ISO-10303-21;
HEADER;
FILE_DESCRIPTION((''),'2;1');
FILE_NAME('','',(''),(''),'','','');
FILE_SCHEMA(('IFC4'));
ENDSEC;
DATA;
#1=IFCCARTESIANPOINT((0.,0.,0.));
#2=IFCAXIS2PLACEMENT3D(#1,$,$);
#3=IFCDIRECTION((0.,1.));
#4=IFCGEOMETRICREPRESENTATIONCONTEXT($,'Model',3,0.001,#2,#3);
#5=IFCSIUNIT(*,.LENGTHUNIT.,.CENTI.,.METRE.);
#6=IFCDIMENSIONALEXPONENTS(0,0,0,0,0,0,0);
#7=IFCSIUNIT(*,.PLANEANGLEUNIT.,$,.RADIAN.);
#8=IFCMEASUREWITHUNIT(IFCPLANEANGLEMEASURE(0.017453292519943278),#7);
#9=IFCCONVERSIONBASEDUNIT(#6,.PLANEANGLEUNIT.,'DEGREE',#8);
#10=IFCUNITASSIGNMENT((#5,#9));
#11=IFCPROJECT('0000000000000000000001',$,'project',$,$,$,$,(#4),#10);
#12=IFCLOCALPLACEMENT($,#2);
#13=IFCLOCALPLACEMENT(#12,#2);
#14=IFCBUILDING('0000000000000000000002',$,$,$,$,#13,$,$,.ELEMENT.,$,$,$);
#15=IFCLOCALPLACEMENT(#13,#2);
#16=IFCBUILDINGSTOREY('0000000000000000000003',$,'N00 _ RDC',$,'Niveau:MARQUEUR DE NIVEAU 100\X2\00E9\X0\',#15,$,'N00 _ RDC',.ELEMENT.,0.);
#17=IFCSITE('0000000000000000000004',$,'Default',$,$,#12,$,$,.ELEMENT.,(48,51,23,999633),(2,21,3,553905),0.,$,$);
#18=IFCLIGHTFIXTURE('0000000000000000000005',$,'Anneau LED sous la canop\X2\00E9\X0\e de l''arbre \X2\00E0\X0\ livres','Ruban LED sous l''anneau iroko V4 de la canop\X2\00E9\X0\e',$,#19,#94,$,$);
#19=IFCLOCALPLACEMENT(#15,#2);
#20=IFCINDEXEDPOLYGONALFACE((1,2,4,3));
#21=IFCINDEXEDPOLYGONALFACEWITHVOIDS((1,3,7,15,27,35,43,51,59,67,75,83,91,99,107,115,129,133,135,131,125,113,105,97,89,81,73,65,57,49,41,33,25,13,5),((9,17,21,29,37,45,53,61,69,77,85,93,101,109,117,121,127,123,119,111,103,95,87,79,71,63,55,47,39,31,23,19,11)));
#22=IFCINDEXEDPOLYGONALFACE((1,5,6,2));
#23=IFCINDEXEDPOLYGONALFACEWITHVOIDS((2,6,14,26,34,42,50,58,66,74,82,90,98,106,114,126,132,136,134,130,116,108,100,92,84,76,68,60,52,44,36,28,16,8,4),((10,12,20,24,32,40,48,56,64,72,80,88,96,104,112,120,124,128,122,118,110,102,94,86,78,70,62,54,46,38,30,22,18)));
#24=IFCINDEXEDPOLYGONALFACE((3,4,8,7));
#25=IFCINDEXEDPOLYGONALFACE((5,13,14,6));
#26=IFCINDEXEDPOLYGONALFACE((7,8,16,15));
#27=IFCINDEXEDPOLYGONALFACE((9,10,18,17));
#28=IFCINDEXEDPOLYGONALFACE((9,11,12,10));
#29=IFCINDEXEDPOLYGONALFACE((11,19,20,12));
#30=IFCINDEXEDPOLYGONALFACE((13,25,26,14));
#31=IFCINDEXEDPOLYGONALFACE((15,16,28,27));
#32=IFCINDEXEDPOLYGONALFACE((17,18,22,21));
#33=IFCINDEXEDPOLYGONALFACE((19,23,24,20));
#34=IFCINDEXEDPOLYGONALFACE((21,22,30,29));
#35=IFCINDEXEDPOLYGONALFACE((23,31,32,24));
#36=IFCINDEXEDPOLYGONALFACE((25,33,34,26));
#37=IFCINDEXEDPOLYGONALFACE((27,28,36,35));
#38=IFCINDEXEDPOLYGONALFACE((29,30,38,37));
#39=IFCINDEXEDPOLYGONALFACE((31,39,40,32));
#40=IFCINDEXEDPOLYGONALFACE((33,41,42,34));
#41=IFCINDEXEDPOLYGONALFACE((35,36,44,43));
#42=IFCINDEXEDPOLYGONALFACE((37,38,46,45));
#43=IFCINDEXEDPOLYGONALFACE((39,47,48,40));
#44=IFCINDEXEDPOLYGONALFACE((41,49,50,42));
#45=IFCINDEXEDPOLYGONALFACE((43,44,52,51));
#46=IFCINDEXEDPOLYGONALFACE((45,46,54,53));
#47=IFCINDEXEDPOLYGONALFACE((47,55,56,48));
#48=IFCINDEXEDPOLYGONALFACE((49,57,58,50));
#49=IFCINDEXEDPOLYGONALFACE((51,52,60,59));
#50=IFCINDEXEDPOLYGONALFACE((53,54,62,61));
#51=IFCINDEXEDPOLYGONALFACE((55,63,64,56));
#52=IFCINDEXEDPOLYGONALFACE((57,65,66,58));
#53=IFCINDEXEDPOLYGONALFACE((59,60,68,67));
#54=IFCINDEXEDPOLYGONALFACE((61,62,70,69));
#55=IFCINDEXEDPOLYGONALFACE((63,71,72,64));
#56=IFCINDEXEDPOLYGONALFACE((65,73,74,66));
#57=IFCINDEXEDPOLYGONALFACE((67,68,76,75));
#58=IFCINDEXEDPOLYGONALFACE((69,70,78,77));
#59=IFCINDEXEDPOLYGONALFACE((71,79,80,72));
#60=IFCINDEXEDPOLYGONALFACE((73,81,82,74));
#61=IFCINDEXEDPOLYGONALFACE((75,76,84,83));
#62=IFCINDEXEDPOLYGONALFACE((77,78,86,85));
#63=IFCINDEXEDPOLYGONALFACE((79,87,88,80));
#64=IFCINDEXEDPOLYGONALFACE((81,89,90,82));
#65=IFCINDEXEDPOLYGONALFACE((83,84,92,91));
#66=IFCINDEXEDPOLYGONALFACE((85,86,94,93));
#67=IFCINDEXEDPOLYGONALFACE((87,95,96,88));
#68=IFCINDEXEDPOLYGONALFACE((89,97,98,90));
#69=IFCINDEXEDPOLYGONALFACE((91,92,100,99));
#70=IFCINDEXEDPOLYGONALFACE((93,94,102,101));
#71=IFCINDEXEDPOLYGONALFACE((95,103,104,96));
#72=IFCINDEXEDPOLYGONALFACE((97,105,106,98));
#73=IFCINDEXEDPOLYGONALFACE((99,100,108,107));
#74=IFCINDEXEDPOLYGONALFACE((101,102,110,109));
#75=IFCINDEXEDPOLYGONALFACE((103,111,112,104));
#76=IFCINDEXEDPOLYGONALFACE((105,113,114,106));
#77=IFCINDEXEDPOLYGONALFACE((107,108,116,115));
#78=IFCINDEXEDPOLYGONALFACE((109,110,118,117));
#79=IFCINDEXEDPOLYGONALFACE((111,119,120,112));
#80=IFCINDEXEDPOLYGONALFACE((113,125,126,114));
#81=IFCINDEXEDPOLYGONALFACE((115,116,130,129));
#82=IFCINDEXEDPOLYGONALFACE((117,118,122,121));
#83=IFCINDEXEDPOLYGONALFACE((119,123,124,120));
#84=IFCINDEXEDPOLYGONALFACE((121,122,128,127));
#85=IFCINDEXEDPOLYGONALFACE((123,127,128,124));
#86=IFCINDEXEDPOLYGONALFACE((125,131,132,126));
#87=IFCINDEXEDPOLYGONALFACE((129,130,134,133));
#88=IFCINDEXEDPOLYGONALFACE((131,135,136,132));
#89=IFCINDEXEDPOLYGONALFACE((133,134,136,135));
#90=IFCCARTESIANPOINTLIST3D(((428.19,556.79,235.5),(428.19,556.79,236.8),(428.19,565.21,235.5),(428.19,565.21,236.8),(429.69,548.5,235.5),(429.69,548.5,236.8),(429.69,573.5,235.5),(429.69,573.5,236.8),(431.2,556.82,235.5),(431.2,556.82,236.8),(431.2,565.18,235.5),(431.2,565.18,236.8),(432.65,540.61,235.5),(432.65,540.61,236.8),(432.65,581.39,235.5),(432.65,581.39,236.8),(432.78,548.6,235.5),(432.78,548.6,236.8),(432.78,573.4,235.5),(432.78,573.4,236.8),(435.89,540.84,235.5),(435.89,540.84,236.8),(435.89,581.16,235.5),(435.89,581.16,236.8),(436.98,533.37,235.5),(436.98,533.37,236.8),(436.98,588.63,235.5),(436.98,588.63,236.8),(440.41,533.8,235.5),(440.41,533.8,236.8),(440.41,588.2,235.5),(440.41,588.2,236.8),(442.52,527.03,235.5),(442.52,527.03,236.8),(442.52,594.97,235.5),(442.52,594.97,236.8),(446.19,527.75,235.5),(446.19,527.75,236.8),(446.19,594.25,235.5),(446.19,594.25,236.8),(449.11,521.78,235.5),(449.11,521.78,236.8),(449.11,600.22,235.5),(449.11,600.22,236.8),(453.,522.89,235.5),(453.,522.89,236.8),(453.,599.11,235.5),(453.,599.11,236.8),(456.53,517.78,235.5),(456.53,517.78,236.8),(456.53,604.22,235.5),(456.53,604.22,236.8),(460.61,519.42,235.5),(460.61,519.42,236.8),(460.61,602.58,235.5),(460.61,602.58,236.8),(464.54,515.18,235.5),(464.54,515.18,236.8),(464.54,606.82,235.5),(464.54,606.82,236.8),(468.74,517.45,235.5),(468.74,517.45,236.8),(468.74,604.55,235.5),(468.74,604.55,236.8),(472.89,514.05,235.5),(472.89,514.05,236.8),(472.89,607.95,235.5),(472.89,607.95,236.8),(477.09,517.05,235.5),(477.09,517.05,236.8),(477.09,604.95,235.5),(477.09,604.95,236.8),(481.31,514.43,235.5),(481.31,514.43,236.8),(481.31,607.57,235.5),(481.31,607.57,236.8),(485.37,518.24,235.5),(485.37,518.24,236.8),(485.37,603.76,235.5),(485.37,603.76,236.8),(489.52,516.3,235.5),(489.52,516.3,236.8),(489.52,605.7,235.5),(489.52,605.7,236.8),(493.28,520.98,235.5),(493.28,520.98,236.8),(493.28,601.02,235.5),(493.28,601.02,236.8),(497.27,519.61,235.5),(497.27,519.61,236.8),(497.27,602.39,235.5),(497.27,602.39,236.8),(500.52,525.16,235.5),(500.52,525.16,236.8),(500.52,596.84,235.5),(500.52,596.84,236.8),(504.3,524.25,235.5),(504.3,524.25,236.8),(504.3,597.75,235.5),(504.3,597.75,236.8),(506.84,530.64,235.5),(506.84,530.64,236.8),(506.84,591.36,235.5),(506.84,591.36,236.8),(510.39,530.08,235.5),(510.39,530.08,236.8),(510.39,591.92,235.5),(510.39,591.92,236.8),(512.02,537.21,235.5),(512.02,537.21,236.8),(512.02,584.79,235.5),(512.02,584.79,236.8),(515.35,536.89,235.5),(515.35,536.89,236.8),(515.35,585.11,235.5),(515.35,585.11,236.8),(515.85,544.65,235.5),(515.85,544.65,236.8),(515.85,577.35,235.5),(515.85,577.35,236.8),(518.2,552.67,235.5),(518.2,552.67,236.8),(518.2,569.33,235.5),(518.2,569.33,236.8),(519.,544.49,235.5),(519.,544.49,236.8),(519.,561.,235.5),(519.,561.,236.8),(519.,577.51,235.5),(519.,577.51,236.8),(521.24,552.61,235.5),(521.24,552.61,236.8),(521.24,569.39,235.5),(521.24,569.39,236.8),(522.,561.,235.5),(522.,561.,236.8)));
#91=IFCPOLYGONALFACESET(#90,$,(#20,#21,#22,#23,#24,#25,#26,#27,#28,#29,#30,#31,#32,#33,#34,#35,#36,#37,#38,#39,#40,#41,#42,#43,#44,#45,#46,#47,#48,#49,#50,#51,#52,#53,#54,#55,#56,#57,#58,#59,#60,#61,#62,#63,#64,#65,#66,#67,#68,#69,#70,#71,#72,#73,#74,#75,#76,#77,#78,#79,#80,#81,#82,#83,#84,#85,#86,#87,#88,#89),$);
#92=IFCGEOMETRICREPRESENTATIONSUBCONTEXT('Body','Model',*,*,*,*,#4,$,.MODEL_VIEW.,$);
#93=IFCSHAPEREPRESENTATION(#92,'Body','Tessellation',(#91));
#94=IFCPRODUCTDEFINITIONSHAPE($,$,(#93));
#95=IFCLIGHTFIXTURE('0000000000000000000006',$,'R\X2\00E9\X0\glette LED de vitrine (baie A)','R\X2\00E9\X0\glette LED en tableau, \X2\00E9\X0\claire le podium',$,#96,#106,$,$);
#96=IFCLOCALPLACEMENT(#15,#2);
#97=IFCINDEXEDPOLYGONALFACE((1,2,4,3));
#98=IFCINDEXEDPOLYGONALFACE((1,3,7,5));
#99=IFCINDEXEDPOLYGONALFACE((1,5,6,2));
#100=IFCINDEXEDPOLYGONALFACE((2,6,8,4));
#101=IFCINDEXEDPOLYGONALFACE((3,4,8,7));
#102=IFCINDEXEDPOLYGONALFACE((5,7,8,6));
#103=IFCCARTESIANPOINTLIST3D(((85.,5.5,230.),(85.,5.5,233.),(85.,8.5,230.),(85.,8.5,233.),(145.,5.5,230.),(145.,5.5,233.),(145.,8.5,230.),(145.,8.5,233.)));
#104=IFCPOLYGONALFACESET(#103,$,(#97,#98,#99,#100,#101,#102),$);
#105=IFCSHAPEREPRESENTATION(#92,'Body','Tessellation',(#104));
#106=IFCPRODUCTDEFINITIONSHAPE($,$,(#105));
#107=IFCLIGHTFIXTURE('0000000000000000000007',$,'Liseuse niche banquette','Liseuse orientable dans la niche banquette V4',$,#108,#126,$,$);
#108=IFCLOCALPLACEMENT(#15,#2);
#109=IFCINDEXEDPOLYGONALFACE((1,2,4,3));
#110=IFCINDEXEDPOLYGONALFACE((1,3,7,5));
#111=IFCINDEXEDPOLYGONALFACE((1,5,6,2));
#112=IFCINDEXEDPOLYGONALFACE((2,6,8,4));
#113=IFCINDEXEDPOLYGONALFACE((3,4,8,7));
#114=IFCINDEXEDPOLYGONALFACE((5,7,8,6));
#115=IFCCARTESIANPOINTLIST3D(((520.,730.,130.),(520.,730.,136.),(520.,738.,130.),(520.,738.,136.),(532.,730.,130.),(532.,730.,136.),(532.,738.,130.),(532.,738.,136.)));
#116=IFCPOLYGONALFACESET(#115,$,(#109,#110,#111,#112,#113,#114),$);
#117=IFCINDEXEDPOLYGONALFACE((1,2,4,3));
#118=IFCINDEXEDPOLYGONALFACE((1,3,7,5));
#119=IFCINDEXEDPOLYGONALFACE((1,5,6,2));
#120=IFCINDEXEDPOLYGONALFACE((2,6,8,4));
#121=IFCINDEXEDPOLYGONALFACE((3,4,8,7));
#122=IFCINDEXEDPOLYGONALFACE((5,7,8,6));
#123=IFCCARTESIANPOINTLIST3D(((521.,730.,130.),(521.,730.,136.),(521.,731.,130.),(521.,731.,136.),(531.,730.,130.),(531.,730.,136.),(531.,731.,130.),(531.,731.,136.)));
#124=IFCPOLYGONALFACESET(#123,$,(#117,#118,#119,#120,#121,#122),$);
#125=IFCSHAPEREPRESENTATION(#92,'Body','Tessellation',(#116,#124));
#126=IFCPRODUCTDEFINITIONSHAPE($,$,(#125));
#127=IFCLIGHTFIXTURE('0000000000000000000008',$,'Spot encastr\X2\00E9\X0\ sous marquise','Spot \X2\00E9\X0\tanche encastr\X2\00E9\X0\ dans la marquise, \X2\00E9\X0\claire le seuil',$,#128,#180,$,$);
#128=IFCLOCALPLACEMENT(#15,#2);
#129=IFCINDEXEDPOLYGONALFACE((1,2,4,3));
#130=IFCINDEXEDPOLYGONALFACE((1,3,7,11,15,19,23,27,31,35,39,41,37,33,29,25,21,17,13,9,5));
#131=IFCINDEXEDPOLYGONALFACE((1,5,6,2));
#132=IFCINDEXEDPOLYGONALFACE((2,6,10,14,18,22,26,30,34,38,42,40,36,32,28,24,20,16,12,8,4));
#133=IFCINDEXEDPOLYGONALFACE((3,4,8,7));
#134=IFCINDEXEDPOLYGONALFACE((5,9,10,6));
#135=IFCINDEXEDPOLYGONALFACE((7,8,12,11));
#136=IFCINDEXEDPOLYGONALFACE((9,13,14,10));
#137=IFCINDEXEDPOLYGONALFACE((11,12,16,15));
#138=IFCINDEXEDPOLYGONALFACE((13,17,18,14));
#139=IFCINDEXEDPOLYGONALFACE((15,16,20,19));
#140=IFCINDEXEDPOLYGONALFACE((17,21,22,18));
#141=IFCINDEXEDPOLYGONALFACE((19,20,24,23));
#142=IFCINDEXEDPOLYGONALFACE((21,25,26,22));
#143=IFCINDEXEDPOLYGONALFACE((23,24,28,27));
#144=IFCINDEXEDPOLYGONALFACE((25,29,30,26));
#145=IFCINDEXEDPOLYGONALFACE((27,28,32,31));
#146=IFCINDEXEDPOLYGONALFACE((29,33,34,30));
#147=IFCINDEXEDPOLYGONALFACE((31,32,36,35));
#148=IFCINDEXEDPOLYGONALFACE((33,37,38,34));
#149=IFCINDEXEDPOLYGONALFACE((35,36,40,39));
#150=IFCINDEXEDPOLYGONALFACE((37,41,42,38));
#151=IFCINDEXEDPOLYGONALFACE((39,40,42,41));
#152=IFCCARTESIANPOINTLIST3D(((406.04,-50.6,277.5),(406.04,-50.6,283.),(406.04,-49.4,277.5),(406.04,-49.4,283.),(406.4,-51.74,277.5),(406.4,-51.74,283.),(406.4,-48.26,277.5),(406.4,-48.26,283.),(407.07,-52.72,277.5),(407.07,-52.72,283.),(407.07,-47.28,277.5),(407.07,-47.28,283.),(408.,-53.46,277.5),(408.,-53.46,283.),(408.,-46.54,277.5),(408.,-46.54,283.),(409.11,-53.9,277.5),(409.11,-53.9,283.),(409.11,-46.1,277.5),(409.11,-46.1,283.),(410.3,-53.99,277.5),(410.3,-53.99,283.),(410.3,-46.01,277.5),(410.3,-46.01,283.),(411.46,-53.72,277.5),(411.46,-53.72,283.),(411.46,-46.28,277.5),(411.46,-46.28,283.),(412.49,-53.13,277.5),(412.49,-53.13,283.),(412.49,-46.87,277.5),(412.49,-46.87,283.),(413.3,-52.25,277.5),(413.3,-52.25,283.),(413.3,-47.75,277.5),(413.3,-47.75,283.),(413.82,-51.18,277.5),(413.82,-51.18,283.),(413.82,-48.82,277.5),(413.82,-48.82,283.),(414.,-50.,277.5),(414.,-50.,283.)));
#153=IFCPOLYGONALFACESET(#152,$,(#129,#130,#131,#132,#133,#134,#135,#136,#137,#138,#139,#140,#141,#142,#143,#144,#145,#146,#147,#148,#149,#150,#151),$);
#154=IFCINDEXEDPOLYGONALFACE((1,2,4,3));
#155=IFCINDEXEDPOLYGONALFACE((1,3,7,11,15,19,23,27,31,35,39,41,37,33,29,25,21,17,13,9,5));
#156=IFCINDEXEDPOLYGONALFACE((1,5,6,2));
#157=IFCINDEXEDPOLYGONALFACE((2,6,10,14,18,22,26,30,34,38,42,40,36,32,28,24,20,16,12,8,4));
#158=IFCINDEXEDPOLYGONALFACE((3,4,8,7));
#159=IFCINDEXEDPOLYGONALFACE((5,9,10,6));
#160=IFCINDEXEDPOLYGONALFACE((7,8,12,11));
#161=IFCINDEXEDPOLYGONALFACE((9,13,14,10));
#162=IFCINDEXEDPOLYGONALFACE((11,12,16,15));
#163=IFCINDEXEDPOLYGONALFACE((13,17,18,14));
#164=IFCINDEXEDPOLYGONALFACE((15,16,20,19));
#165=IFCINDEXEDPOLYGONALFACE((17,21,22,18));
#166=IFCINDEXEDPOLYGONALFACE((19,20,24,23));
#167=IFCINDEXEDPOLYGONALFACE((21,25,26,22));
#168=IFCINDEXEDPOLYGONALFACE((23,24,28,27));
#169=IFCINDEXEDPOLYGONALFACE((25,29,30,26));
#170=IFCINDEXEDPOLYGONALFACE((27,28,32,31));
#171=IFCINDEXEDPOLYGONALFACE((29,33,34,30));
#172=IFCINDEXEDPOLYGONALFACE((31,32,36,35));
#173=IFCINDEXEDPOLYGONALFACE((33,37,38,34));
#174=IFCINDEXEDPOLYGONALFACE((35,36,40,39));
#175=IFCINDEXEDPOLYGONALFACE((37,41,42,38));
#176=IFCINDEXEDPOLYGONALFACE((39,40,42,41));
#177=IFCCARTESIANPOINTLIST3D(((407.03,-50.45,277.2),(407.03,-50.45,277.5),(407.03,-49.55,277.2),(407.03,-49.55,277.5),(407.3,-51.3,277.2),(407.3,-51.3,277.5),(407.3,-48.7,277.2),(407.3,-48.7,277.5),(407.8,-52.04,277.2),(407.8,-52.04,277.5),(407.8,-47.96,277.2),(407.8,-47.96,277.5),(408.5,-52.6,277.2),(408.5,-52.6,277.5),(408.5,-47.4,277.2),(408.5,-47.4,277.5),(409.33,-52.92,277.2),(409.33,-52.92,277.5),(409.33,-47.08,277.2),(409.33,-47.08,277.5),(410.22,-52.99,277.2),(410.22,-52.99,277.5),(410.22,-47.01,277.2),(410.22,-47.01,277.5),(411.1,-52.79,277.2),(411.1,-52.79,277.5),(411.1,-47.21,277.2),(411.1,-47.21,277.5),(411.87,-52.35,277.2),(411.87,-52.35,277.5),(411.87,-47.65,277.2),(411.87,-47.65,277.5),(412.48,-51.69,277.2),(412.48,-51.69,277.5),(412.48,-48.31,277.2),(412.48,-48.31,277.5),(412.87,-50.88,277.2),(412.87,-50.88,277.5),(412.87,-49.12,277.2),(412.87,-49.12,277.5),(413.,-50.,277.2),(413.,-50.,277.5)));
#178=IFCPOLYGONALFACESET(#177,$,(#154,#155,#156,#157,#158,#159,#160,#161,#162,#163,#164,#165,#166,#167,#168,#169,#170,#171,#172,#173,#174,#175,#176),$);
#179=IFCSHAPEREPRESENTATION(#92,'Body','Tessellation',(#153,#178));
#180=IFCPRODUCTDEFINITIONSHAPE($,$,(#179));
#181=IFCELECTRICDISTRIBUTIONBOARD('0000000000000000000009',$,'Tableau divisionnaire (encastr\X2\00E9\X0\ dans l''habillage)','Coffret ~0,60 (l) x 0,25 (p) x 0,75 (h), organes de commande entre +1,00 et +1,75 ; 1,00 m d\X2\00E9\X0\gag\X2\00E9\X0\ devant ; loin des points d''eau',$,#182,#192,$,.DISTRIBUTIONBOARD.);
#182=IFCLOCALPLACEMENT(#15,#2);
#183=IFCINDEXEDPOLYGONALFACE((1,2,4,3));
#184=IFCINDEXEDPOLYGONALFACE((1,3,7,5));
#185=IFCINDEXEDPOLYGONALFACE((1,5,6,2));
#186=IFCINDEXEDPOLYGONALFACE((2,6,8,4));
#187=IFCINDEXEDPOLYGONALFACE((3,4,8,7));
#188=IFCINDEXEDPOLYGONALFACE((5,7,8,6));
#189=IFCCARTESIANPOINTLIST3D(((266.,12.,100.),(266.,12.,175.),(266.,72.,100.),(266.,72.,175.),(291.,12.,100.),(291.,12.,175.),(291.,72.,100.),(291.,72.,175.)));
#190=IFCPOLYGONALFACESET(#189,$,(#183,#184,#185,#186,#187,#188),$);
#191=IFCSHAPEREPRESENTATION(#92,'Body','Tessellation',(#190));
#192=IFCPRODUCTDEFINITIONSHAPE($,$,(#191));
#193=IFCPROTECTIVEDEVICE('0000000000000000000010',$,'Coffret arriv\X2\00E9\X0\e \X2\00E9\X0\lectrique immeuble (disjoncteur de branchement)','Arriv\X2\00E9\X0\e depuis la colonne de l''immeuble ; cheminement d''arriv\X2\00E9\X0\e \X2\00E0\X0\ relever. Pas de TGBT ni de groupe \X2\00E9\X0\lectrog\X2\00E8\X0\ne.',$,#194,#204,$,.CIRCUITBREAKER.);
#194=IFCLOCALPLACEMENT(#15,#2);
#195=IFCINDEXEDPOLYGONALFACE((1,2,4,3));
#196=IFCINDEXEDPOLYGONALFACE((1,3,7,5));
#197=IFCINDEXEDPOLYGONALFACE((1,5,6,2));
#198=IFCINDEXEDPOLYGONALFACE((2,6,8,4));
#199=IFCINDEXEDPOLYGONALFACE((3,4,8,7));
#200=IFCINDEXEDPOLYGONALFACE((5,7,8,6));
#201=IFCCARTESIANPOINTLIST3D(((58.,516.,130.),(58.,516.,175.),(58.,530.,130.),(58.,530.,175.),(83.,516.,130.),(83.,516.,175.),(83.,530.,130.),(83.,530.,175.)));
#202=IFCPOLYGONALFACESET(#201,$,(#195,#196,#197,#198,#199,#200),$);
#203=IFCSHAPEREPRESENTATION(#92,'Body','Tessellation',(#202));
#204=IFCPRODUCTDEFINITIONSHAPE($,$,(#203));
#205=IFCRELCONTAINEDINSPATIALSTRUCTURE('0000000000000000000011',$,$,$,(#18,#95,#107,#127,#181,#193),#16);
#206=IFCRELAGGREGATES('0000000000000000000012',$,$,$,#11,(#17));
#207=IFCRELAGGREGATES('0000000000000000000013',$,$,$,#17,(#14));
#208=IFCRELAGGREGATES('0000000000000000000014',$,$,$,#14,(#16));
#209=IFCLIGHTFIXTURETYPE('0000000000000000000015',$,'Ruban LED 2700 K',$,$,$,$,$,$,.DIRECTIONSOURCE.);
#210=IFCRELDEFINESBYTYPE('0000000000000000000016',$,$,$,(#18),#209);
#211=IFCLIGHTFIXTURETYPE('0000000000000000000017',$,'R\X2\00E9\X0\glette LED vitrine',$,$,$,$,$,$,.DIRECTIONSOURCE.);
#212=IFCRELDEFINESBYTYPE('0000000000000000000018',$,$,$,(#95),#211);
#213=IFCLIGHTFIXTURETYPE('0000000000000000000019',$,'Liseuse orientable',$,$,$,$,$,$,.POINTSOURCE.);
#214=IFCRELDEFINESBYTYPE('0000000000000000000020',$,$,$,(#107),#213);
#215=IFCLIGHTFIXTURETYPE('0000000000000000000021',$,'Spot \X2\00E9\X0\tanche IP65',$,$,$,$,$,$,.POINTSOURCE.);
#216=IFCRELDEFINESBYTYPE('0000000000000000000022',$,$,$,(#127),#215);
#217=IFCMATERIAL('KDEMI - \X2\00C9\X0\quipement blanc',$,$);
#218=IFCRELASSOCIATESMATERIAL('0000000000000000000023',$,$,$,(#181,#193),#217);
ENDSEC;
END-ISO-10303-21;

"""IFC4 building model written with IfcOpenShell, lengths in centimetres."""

from ifc_helpers import new_model, entity, si_unit, converted_unit, direction, frame, frame_2d, origin, origin_with_axes, place, context, subcontext, project, spatial, rectangle, circle, hollow_circle, extrude, material, type_object, element, save


model = new_model("IFC4")

# Units and contexts
model_context = context("Model", 3, precision=0.001, world=origin(), true_north=direction((0.0, 1.0)))
body_context = subcontext(model_context, "Body", "Model", "MODEL_VIEW")
ifc_project = project(units=[si_unit("LENGTHUNIT", "METRE", prefix="CENTI"), converted_unit("PLANEANGLEUNIT", "DEGREE", entity("IfcPlaneAngleMeasure", 0.017453292519943278), si_unit("PLANEANGLEUNIT", "RADIAN"), dimensions=[0, 0, 0, 0, 0, 0, 0])], contexts=[model_context])

# Site, building, storey
site_placement = place(None, origin())
site = spatial("IfcSite", under=ifc_project, at=site_placement, Name="Default", CompositionType="ELEMENT", RefLatitude=(48, 51, 23, 999633), RefLongitude=(2, 21, 3, 553905), RefElevation=0.0)
building_placement = place(site_placement, origin())
building = spatial("IfcBuilding", under=site, at=building_placement, CompositionType="ELEMENT")
storey_placement = place(building_placement, origin())
storey = spatial("IfcBuildingStorey", under=building, at=storey_placement, Name="N00 _ RDC", ObjectType="Niveau:MARQUEUR DE NIVEAU 100é", LongName="N00 _ RDC", CompositionType="ELEMENT", Elevation=0.0)

# Light fixtures
light_fixture_type_1 = type_object("IfcLightFixtureType", Name="Ruban LED 2700 K", PredefinedType="DIRECTIONSOURCE")
light_fixture_1_placement = place(storey_placement, origin_with_axes())
element("IfcLightFixture", 1, at=light_fixture_1_placement, inside=storey, type_object=light_fixture_type_1, Name="Anneau LED sous la canopée de l'arbre à livres", Description="Ruban LED sous l'anneau iroko V4 de la canopée", context=body_context, shape_type="SweptSolid", body=[
    extrude(hollow_circle(Radius=47.0, WallThickness=3.0, at=frame_2d((475.0, 561.0))), frame((0.0, 0.0, 235.5)), (0.0, 0.0, 1.0), 1.3),
])
light_fixture_type_2 = type_object("IfcLightFixtureType", Name="Réglette LED vitrine", PredefinedType="DIRECTIONSOURCE")
light_fixture_2_placement = place(storey_placement, origin_with_axes())
element("IfcLightFixture", 2, at=light_fixture_2_placement, inside=storey, type_object=light_fixture_type_2, Name="Réglette LED de vitrine (baie A)", Description="Réglette LED en tableau, éclaire le podium", context=body_context, shape_type="SweptSolid", body=[
    extrude(rectangle(XDim=60.0, YDim=3.0, at=frame_2d((115.0, 7.0))), frame((0.0, 0.0, 230.0)), (0.0, 0.0, 1.0), 3.0),
])
light_fixture_type_3 = type_object("IfcLightFixtureType", Name="Liseuse orientable", PredefinedType="POINTSOURCE")
light_fixture_3_placement = place(storey_placement, origin_with_axes())
element("IfcLightFixture", 3, at=light_fixture_3_placement, inside=storey, type_object=light_fixture_type_3, Name="Liseuse niche banquette", Description="Liseuse orientable dans la niche banquette V4", context=body_context, shape_type="SweptSolid", body=[
    extrude(rectangle(XDim=12.0, YDim=8.0, at=frame_2d((526.0, 734.0))), frame((0.0, 0.0, 130.0)), (0.0, 0.0, 1.0), 6.0),
    extrude(rectangle(XDim=10.0, YDim=1.0, at=frame_2d((526.0, 730.5))), frame((0.0, 0.0, 130.0)), (0.0, 0.0, 1.0), 6.0),
])
light_fixture_type_4 = type_object("IfcLightFixtureType", Name="Spot étanche IP65", PredefinedType="POINTSOURCE")
light_fixture_4_placement = place(storey_placement, origin_with_axes())
element("IfcLightFixture", 4, at=light_fixture_4_placement, inside=storey, type_object=light_fixture_type_4, Name="Spot encastré sous marquise", Description="Spot étanche encastré dans la marquise, éclaire le seuil", context=body_context, shape_type="SweptSolid", body=[
    extrude(circle(Radius=4.0, at=frame_2d((410.0, -50.0))), frame((0.0, 0.0, 277.5)), (0.0, 0.0, 1.0), 5.5),
    extrude(circle(Radius=3.0, at=frame_2d((410.0, -50.0))), frame((0.0, 0.0, 277.2)), (0.0, 0.0, 1.0), 0.3),
])

# Electric distribution board
ifc_material_1 = material(Name="KDEMI - Équipement blanc")
electric_distribution_board_placement = place(storey_placement, origin_with_axes())
element("IfcElectricDistributionBoard", 5, at=electric_distribution_board_placement, inside=storey, material=ifc_material_1, Name="Tableau divisionnaire (encastré dans l'habillage)", Description="Coffret ~0,60 (l) x 0,25 (p) x 0,75 (h), organes de commande entre +1,00 et +1,75 ; 1,00 m dégagé devant ; loin des points d'eau", PredefinedType="DISTRIBUTIONBOARD", context=body_context, shape_type="SweptSolid", body=[
    extrude(rectangle(XDim=25.0, YDim=60.0, at=frame_2d((278.5, 42.0))), frame((0.0, 0.0, 100.0)), (0.0, 0.0, 1.0), 75.0),
])

# Protective device
protective_device_placement = place(storey_placement, origin_with_axes())
element("IfcProtectiveDevice", 6, at=protective_device_placement, inside=storey, material=ifc_material_1, Name="Coffret arrivée électrique immeuble (disjoncteur de branchement)", Description="Arrivée depuis la colonne de l'immeuble ; cheminement d'arrivée à relever. Pas de TGBT ni de groupe électrogène.", PredefinedType="CIRCUITBREAKER", context=body_context, shape_type="SweptSolid", body=[
    extrude(rectangle(XDim=25.0, YDim=14.0, at=frame_2d((70.5, 523.0))), frame((0.0, 0.0, 130.0)), (0.0, 0.0, 1.0), 45.0),
])

save(model, "model.ifc")
